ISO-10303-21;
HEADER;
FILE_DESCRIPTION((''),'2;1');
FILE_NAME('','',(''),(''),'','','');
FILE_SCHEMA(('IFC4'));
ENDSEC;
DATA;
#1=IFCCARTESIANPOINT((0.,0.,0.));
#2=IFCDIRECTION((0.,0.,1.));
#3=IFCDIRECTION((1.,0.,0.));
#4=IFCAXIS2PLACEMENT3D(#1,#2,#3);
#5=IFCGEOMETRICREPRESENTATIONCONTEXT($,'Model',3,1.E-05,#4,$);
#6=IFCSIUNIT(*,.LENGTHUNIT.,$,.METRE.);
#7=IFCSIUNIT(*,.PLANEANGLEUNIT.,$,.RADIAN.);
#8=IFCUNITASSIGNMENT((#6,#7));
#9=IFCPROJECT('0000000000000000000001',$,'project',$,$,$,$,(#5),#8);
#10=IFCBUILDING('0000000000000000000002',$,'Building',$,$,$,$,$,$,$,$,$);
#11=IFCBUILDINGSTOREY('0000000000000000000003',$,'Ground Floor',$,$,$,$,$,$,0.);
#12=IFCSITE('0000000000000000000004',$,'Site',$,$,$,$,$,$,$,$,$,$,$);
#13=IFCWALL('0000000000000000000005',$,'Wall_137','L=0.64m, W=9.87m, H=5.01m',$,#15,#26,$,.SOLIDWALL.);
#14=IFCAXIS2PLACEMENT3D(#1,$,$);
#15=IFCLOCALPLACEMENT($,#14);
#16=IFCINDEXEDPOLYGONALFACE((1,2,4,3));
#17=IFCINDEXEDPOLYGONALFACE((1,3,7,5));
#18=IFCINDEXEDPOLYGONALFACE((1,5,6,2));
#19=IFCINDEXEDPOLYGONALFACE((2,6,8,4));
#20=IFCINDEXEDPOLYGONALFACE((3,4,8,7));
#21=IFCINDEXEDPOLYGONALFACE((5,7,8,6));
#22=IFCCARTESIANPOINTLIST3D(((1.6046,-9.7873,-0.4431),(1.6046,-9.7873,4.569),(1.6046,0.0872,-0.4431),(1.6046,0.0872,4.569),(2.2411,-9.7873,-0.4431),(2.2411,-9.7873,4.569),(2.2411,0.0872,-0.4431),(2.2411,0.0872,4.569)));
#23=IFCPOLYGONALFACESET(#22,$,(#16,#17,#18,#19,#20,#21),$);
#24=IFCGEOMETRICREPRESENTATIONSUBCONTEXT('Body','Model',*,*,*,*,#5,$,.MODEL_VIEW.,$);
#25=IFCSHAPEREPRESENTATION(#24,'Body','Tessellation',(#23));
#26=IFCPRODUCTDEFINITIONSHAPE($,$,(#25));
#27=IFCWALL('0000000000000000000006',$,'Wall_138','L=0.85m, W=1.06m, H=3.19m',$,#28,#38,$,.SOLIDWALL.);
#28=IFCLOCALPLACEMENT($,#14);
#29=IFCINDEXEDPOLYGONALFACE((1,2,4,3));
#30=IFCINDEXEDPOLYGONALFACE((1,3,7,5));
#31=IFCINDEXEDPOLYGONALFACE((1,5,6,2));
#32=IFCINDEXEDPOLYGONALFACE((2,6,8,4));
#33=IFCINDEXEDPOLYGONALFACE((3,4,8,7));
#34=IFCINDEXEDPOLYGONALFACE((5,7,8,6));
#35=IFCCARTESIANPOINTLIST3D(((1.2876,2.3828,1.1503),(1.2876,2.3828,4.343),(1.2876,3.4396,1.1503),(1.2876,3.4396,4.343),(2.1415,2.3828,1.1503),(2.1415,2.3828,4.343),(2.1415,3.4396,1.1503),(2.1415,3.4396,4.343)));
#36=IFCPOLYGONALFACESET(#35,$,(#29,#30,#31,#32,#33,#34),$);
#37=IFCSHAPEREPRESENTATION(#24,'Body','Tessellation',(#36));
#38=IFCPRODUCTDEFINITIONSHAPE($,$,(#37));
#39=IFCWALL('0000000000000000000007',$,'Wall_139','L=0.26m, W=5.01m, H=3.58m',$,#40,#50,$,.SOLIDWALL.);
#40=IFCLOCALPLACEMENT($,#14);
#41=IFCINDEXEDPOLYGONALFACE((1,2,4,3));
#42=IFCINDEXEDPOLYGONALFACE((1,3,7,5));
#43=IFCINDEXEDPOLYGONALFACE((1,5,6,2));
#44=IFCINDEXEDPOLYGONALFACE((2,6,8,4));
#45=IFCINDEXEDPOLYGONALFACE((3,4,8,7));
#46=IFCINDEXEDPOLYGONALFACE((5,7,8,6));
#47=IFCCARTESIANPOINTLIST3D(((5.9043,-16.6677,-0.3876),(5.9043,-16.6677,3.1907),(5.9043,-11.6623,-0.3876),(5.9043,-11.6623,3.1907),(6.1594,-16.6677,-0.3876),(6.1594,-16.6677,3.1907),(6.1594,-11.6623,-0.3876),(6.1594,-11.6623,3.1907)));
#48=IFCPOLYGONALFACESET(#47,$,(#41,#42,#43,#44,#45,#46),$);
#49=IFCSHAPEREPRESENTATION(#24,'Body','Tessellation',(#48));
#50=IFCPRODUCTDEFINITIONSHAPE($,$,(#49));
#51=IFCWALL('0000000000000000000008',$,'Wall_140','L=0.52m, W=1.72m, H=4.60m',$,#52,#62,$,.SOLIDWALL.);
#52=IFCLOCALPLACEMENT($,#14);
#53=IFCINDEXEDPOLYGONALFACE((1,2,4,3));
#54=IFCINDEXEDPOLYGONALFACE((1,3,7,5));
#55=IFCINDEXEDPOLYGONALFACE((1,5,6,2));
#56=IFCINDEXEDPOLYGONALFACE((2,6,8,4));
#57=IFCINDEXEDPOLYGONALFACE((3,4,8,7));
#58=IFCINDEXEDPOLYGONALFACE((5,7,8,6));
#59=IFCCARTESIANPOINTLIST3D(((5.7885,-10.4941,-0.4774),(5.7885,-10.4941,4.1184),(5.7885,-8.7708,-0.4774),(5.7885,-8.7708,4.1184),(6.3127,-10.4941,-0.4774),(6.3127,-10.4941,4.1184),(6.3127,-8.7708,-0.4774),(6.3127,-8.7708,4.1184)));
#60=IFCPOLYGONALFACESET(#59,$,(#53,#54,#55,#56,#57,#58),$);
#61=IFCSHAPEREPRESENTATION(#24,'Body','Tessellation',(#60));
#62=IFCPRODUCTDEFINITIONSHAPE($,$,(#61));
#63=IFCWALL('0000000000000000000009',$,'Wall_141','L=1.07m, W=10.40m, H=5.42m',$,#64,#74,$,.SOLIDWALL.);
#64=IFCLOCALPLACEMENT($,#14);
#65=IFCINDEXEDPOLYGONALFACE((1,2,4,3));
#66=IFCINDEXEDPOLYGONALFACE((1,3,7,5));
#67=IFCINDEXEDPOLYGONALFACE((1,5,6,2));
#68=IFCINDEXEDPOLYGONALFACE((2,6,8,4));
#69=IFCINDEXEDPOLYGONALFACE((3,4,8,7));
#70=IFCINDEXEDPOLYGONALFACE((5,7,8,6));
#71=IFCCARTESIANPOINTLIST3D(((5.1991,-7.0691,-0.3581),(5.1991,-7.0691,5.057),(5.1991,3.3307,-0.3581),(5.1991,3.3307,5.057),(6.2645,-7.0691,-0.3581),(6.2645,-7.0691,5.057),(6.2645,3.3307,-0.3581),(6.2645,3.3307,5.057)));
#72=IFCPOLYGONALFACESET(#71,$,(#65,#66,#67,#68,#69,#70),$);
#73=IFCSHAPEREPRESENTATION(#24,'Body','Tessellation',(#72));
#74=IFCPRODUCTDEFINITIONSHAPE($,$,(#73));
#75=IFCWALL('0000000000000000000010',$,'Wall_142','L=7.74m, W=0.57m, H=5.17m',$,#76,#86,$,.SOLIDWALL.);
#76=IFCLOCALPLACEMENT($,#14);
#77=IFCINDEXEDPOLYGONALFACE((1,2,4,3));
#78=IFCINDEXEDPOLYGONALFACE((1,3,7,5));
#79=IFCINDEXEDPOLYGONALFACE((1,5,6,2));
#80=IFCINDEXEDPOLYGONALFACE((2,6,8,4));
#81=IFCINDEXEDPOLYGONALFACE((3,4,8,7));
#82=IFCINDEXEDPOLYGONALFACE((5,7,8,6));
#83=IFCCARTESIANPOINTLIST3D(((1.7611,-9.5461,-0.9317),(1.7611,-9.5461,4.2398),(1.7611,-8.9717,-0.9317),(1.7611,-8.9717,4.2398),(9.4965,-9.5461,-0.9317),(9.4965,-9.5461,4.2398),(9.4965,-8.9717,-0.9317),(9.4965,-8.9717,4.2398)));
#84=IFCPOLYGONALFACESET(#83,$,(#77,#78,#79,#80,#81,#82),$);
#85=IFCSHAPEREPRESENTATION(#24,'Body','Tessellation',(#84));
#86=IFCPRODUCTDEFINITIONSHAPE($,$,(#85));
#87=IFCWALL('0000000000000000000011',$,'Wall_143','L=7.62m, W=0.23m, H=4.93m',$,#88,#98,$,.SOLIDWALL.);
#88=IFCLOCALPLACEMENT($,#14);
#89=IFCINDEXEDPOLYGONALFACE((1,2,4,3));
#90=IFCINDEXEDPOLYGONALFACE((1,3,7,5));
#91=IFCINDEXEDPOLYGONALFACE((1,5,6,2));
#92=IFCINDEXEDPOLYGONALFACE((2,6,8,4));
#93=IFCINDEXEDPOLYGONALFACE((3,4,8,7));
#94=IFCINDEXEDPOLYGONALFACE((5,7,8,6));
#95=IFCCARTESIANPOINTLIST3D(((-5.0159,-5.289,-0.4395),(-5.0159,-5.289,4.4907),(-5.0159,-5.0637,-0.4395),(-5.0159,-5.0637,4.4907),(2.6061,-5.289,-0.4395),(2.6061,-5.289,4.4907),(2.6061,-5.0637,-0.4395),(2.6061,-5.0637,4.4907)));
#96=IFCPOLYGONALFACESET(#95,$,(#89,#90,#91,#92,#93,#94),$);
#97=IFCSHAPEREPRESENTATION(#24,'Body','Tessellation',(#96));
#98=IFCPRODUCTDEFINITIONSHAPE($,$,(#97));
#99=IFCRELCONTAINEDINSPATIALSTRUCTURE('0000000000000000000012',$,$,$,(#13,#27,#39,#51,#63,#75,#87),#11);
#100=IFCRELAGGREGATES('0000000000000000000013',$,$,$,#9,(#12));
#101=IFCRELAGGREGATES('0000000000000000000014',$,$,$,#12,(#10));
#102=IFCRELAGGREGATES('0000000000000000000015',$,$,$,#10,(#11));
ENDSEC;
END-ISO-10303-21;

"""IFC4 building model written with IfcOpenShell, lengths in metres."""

from ifc_helpers import new_model, si_unit, frame, origin_with_axes, origin_2d, context, subcontext, project, spatial, rectangle, extrude, element, save


model = new_model("IFC4")

# Units and contexts
model_context = context("Model", 3, precision=1e-05, world=origin_with_axes())
body_context = subcontext(model_context, "Body", "Model", "MODEL_VIEW")
ifc_project = project(units=[si_unit("LENGTHUNIT", "METRE"), si_unit("PLANEANGLEUNIT", "RADIAN")], contexts=[model_context])

# Site, building, storey
site = spatial("IfcSite", under=ifc_project, Name="Site")
building = spatial("IfcBuilding", under=site, Name="Building")
storey = spatial("IfcBuildingStorey", under=building, Name="Ground Floor", Elevation=0.0)

# Walls
element("IfcWall", 1, inside=storey, Name="Wall_137", Description="L=0.64m, W=9.87m, H=5.01m", PredefinedType="SOLIDWALL", context=body_context, shape_type="SweptSolid", body=[
    extrude(rectangle(XDim=0.6365, YDim=9.8745, at=origin_2d()), frame((1.9229, -4.8501, -0.4431), z_axis=(0.0, 0.0, 1.0), x_axis=(1.0, 0.0, 0.0)), (0.0, 0.0, 1.0), 5.0121),
])
element("IfcWall", 2, inside=storey, Name="Wall_138", Description="L=0.85m, W=1.06m, H=3.19m", PredefinedType="SOLIDWALL", context=body_context, shape_type="SweptSolid", body=[
    extrude(rectangle(XDim=0.8539, YDim=1.0568, at=origin_2d()), frame((1.7145, 2.9112, 1.1503), z_axis=(0.0, 0.0, 1.0), x_axis=(1.0, 0.0, 0.0)), (0.0, 0.0, 1.0), 3.1927),
])
element("IfcWall", 3, inside=storey, Name="Wall_139", Description="L=0.26m, W=5.01m, H=3.58m", PredefinedType="SOLIDWALL", context=body_context, shape_type="SweptSolid", body=[
    extrude(rectangle(XDim=0.255, YDim=5.0054, at=origin_2d()), frame((6.0319, -14.165, -0.3876), z_axis=(0.0, 0.0, 1.0), x_axis=(1.0, 0.0, 0.0)), (0.0, 0.0, 1.0), 3.5783),
])
element("IfcWall", 4, inside=storey, Name="Wall_140", Description="L=0.52m, W=1.72m, H=4.60m", PredefinedType="SOLIDWALL", context=body_context, shape_type="SweptSolid", body=[
    extrude(rectangle(XDim=0.5242, YDim=1.7233, at=origin_2d()), frame((6.0506, -9.6325, -0.4774), z_axis=(0.0, 0.0, 1.0), x_axis=(1.0, 0.0, 0.0)), (0.0, 0.0, 1.0), 4.5957),
])
element("IfcWall", 5, inside=storey, Name="Wall_141", Description="L=1.07m, W=10.40m, H=5.42m", PredefinedType="SOLIDWALL", context=body_context, shape_type="SweptSolid", body=[
    extrude(rectangle(XDim=1.0655, YDim=10.3998, at=origin_2d()), frame((5.7318, -1.8692, -0.3581), z_axis=(0.0, 0.0, 1.0), x_axis=(1.0, 0.0, 0.0)), (0.0, 0.0, 1.0), 5.415),
])
element("IfcWall", 6, inside=storey, Name="Wall_142", Description="L=7.74m, W=0.57m, H=5.17m", PredefinedType="SOLIDWALL", context=body_context, shape_type="SweptSolid", body=[
    extrude(rectangle(XDim=7.7353, YDim=0.5744, at=origin_2d()), frame((5.6288, -9.2589, -0.9317), z_axis=(0.0, 0.0, 1.0), x_axis=(1.0, 0.0, 0.0)), (0.0, 0.0, 1.0), 5.1715),
])
element("IfcWall", 7, inside=storey, Name="Wall_143", Description="L=7.62m, W=0.23m, H=4.93m", PredefinedType="SOLIDWALL", context=body_context, shape_type="SweptSolid", body=[
    extrude(rectangle(XDim=7.622, YDim=0.2253, at=origin_2d()), frame((-1.2049, -5.1763, -0.4395), z_axis=(0.0, 0.0, 1.0), x_axis=(1.0, 0.0, 0.0)), (0.0, 0.0, 1.0), 4.9302),
])

save(model, "model.ifc")
